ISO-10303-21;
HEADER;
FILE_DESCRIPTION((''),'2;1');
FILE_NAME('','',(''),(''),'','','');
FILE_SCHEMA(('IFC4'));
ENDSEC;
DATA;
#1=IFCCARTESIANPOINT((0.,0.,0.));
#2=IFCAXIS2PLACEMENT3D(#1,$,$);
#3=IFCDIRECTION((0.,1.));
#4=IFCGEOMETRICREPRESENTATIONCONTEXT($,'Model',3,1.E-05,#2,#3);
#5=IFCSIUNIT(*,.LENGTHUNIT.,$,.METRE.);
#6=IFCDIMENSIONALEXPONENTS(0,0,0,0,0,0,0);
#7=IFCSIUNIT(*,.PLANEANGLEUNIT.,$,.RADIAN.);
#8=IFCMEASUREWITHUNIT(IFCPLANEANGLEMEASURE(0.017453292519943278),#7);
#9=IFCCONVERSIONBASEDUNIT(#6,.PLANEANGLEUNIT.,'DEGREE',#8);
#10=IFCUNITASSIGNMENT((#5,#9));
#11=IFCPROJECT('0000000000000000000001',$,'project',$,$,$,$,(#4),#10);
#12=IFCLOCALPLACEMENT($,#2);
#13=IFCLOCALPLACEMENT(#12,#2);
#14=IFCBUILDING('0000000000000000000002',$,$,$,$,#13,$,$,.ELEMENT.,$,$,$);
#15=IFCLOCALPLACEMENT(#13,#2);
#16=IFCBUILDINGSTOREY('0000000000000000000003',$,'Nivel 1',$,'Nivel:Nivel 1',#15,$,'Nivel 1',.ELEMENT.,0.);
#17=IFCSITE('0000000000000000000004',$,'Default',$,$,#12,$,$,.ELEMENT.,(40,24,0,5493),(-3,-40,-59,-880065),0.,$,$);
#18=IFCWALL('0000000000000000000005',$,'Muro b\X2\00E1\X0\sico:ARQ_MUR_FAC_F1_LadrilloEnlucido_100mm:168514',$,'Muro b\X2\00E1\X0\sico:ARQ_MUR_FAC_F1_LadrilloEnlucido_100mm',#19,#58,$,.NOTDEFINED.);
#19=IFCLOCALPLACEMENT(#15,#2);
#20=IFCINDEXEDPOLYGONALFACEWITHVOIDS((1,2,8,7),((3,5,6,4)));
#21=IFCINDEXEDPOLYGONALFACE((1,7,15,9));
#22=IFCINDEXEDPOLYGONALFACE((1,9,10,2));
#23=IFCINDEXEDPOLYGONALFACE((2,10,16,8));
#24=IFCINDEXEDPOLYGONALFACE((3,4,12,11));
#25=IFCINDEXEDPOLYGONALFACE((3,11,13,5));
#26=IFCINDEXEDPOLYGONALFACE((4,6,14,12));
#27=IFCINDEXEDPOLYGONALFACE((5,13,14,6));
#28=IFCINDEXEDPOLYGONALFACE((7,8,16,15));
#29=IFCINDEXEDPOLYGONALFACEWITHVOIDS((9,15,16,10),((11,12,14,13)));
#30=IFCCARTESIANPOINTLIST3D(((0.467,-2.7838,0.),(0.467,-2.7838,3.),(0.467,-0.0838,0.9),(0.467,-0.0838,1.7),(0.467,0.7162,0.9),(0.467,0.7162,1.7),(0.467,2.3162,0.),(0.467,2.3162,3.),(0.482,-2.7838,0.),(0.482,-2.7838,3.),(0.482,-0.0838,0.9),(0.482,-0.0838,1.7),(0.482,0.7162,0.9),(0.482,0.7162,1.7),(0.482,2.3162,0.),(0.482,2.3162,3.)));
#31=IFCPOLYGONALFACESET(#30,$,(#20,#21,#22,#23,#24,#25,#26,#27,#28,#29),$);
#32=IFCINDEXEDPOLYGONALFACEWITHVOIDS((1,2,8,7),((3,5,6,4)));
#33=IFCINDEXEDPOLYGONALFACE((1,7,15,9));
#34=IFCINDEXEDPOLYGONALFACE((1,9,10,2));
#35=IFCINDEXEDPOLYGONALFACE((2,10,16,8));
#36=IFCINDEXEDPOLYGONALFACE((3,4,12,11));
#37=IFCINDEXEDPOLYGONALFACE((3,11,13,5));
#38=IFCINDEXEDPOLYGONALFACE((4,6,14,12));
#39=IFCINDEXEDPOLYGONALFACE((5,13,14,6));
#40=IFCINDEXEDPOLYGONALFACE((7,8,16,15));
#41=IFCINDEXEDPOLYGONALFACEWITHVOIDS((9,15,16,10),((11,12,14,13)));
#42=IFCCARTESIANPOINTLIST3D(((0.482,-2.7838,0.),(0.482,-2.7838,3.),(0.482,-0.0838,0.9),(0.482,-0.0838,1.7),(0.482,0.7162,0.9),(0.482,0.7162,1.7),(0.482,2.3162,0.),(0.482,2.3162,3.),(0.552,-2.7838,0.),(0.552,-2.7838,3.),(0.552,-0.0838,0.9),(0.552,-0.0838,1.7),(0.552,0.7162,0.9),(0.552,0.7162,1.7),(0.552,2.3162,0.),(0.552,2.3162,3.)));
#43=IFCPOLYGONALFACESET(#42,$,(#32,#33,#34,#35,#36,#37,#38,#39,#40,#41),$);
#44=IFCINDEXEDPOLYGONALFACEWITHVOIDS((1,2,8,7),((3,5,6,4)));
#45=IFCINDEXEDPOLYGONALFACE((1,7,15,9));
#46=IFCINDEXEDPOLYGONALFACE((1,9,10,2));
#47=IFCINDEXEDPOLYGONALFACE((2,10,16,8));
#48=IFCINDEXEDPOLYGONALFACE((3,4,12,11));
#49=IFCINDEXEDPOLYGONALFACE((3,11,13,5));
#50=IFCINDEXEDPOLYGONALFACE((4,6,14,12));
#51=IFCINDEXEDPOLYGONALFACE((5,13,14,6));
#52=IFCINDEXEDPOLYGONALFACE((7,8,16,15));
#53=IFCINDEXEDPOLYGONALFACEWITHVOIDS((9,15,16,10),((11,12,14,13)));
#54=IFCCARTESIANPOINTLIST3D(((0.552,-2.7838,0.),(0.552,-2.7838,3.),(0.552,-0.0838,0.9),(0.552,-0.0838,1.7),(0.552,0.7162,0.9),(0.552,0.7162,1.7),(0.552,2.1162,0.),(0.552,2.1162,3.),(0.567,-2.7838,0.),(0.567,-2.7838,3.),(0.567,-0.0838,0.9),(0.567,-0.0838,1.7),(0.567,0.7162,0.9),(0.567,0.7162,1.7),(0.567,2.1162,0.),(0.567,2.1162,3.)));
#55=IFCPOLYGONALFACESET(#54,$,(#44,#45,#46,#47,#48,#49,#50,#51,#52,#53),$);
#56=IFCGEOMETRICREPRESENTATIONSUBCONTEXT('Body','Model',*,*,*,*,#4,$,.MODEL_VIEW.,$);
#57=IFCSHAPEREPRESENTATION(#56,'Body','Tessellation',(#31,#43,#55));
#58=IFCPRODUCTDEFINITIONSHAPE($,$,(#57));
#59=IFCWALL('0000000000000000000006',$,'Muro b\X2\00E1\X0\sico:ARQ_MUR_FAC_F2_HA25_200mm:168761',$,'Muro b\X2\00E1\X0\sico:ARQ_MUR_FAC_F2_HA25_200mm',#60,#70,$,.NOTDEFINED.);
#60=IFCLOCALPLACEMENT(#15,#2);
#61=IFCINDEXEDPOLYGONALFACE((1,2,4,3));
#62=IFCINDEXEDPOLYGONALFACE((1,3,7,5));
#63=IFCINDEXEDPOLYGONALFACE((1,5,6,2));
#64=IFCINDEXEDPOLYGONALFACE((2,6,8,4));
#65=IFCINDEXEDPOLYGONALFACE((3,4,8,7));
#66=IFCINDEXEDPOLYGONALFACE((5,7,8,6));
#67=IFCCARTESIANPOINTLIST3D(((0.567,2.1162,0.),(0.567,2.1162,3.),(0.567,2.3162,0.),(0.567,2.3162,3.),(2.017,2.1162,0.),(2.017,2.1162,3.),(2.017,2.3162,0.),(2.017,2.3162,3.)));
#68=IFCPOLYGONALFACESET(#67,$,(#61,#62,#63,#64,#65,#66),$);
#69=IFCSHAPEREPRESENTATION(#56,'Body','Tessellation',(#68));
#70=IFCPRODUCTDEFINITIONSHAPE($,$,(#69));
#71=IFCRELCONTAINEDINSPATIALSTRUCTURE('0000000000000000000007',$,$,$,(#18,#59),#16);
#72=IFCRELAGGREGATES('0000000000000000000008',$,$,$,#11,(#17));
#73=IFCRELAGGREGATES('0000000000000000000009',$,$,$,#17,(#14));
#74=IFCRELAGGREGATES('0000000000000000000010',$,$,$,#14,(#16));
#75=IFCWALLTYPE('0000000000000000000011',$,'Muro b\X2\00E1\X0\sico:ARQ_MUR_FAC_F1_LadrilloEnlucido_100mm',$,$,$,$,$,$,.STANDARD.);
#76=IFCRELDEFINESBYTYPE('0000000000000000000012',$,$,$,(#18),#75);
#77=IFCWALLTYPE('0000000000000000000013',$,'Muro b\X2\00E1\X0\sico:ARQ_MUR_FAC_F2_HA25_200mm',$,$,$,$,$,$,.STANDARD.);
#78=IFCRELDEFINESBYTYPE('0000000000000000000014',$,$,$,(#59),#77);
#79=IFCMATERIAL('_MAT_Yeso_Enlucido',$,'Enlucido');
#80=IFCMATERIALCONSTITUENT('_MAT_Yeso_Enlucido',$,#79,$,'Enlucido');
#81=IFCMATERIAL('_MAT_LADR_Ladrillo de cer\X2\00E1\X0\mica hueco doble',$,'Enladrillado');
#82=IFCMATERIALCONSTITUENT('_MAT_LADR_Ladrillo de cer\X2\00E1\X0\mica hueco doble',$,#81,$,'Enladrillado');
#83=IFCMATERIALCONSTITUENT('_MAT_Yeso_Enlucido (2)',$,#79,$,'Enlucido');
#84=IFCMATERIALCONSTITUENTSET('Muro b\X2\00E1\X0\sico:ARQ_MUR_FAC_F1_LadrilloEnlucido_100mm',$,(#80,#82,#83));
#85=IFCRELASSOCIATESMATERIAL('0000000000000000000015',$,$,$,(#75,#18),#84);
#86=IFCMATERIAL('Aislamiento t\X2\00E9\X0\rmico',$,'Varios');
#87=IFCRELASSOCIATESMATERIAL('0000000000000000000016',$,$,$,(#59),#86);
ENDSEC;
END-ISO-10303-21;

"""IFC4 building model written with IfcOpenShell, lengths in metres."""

from ifc_helpers import new_model, entity, si_unit, converted_unit, direction, frame, origin, place, context, subcontext, project, spatial, indexed_curve, outline, extrude, material, constituent, constituent_set, type_object, element, save


model = new_model("IFC4")

# Units and contexts
model_context = context("Model", 3, precision=1e-05, world=origin(), true_north=direction((0.0, 1.0)))
body_context = subcontext(model_context, "Body", "Model", "MODEL_VIEW")
ifc_project = project(units=[si_unit("LENGTHUNIT", "METRE"), converted_unit("PLANEANGLEUNIT", "DEGREE", entity("IfcPlaneAngleMeasure", 0.017453292519943278), si_unit("PLANEANGLEUNIT", "RADIAN"), dimensions=[0, 0, 0, 0, 0, 0, 0])], contexts=[model_context])

# Site, building, storey
site_placement = place(None, origin())
site = spatial("IfcSite", under=ifc_project, at=site_placement, Name="Default", CompositionType="ELEMENT", RefLatitude=(40, 24, 0, 5493), RefLongitude=(-3, -40, -59, -880065), RefElevation=0.0)
building_placement = place(site_placement, origin())
building = spatial("IfcBuilding", under=site, at=building_placement, CompositionType="ELEMENT")
storey_placement = place(building_placement, origin())
storey = spatial("IfcBuildingStorey", under=building, at=storey_placement, Name="Nivel 1", ObjectType="Nivel:Nivel 1", LongName="Nivel 1", CompositionType="ELEMENT", Elevation=0.0)

# Wall, opening
ifc_material_1 = material(Name="_MAT_Yeso_Enlucido", Category="Enlucido")
ifc_constituent_1 = constituent(ifc_material_1, Name="_MAT_Yeso_Enlucido", Category="Enlucido")
ifc_material_2 = material(Name="_MAT_LADR_Ladrillo de cerámica hueco doble", Category="Enladrillado")
ifc_constituent_2 = constituent(ifc_material_2, Name="_MAT_LADR_Ladrillo de cerámica hueco doble", Category="Enladrillado")
ifc_constituent_3 = constituent(ifc_material_1, Name="_MAT_Yeso_Enlucido (2)", Category="Enlucido")
ifc_constituent_set = constituent_set(constituents=[ifc_constituent_1, ifc_constituent_2, ifc_constituent_3], Name="Muro básico:ARQ_MUR_FAC_F1_LadrilloEnlucido_100mm")
wall_type_1 = type_object("IfcWallType", Name="Muro básico:ARQ_MUR_FAC_F1_LadrilloEnlucido_100mm", PredefinedType="STANDARD", material=ifc_constituent_set)
wall_1_placement = place(storey_placement, frame((0.517, -2.7838, 0.0), z_axis=(0.0, 0.0, 1.0), x_axis=(0.0, 1.0, 0.0)))
wall_1 = element("IfcWall", 1, at=wall_1_placement, inside=storey, type_object=wall_type_1, material=ifc_constituent_set, Name="Muro básico:ARQ_MUR_FAC_F1_LadrilloEnlucido_100mm:168514", ObjectType="Muro básico:ARQ_MUR_FAC_F1_LadrilloEnlucido_100mm", PredefinedType="NOTDEFINED", context=body_context, shape_type="SweptSolid", body=[
    extrude(outline(indexed_curve([(-2.55, -1.5), (2.55, -1.5), (2.55, 1.5), (-2.55, 1.5), (-2.55, -1.5)], self_intersect=False), holes=[indexed_curve([(0.15, -0.6), (0.15, 0.2), (0.95, 0.2), (0.95, -0.6), (0.15, -0.6)], self_intersect=False)]), frame((2.55, 0.05, 1.5), z_axis=(0.0, -1.0, 0.0), x_axis=(1.0, 0.0, 0.0)), (0.0, 0.0, 1.0), 0.015),
    extrude(outline(indexed_curve([(-1.5, -2.55), (1.5, -2.55), (1.5, 2.55), (-1.5, 2.55), (-1.5, -2.55)], self_intersect=False), holes=[indexed_curve([(0.2, -0.15), (0.2, -0.95), (-0.6, -0.95), (-0.6, -0.15), (0.2, -0.15)], self_intersect=False)]), frame((2.55, 0.035, 1.5), z_axis=(0.0, -1.0, 0.0), x_axis=(0.0, 0.0, 1.0)), (0.0, 0.0, 1.0), 0.07),
    extrude(outline(indexed_curve([(-1.5, -2.45), (1.5, -2.45), (1.5, 2.45), (-1.5, 2.45), (-1.5, -2.45)], self_intersect=False), holes=[indexed_curve([(0.2, -0.25), (0.2, -1.05), (-0.6, -1.05), (-0.6, -0.25), (0.2, -0.25)], self_intersect=False)]), frame((2.45, -0.035, 1.5), z_axis=(0.0, -1.0, 0.0), x_axis=(0.0, 0.0, 1.0)), (0.0, 0.0, 1.0), 0.015),
])
opening_placement = place(wall_1_placement, frame((2.7, -0.05, 0.9)))
element("IfcOpeningElement", 2, at=opening_placement, cuts=wall_1, PredefinedType="OPENING", context=body_context, shape_type="SweptSolid", body=[
    extrude(outline(indexed_curve([(0.0, 0.0), (0.8, 0.0), (0.8, 0.8), (0.0, 0.8), (0.0, 0.0)], self_intersect=False)), frame((0.0, 0.0, 0.0), z_axis=(0.0, 1.0, 0.0), x_axis=(0.0, 0.0, 1.0)), (0.0, 0.0, 1.0), 0.1),
])

# Wall
ifc_material_3 = material(Name="Aislamiento térmico", Category="Varios")
wall_type_2 = type_object("IfcWallType", Name="Muro básico:ARQ_MUR_FAC_F2_HA25_200mm", PredefinedType="STANDARD")
wall_2_placement = place(storey_placement, frame((0.567, 2.2162, 0.0)))
element("IfcWall", 3, at=wall_2_placement, inside=storey, type_object=wall_type_2, material=ifc_material_3, Name="Muro básico:ARQ_MUR_FAC_F2_HA25_200mm:168761", ObjectType="Muro básico:ARQ_MUR_FAC_F2_HA25_200mm", PredefinedType="NOTDEFINED", context=body_context, shape_type="SweptSolid", body=[
    extrude(outline(indexed_curve([(1.45, 0.1), (0.0, 0.1), (0.0, -0.1), (1.45, -0.1), (1.45, 0.1)], self_intersect=False)), origin(), (0.0, 0.0, 1.0), 3.0),
])

save(model, "model.ifc")
